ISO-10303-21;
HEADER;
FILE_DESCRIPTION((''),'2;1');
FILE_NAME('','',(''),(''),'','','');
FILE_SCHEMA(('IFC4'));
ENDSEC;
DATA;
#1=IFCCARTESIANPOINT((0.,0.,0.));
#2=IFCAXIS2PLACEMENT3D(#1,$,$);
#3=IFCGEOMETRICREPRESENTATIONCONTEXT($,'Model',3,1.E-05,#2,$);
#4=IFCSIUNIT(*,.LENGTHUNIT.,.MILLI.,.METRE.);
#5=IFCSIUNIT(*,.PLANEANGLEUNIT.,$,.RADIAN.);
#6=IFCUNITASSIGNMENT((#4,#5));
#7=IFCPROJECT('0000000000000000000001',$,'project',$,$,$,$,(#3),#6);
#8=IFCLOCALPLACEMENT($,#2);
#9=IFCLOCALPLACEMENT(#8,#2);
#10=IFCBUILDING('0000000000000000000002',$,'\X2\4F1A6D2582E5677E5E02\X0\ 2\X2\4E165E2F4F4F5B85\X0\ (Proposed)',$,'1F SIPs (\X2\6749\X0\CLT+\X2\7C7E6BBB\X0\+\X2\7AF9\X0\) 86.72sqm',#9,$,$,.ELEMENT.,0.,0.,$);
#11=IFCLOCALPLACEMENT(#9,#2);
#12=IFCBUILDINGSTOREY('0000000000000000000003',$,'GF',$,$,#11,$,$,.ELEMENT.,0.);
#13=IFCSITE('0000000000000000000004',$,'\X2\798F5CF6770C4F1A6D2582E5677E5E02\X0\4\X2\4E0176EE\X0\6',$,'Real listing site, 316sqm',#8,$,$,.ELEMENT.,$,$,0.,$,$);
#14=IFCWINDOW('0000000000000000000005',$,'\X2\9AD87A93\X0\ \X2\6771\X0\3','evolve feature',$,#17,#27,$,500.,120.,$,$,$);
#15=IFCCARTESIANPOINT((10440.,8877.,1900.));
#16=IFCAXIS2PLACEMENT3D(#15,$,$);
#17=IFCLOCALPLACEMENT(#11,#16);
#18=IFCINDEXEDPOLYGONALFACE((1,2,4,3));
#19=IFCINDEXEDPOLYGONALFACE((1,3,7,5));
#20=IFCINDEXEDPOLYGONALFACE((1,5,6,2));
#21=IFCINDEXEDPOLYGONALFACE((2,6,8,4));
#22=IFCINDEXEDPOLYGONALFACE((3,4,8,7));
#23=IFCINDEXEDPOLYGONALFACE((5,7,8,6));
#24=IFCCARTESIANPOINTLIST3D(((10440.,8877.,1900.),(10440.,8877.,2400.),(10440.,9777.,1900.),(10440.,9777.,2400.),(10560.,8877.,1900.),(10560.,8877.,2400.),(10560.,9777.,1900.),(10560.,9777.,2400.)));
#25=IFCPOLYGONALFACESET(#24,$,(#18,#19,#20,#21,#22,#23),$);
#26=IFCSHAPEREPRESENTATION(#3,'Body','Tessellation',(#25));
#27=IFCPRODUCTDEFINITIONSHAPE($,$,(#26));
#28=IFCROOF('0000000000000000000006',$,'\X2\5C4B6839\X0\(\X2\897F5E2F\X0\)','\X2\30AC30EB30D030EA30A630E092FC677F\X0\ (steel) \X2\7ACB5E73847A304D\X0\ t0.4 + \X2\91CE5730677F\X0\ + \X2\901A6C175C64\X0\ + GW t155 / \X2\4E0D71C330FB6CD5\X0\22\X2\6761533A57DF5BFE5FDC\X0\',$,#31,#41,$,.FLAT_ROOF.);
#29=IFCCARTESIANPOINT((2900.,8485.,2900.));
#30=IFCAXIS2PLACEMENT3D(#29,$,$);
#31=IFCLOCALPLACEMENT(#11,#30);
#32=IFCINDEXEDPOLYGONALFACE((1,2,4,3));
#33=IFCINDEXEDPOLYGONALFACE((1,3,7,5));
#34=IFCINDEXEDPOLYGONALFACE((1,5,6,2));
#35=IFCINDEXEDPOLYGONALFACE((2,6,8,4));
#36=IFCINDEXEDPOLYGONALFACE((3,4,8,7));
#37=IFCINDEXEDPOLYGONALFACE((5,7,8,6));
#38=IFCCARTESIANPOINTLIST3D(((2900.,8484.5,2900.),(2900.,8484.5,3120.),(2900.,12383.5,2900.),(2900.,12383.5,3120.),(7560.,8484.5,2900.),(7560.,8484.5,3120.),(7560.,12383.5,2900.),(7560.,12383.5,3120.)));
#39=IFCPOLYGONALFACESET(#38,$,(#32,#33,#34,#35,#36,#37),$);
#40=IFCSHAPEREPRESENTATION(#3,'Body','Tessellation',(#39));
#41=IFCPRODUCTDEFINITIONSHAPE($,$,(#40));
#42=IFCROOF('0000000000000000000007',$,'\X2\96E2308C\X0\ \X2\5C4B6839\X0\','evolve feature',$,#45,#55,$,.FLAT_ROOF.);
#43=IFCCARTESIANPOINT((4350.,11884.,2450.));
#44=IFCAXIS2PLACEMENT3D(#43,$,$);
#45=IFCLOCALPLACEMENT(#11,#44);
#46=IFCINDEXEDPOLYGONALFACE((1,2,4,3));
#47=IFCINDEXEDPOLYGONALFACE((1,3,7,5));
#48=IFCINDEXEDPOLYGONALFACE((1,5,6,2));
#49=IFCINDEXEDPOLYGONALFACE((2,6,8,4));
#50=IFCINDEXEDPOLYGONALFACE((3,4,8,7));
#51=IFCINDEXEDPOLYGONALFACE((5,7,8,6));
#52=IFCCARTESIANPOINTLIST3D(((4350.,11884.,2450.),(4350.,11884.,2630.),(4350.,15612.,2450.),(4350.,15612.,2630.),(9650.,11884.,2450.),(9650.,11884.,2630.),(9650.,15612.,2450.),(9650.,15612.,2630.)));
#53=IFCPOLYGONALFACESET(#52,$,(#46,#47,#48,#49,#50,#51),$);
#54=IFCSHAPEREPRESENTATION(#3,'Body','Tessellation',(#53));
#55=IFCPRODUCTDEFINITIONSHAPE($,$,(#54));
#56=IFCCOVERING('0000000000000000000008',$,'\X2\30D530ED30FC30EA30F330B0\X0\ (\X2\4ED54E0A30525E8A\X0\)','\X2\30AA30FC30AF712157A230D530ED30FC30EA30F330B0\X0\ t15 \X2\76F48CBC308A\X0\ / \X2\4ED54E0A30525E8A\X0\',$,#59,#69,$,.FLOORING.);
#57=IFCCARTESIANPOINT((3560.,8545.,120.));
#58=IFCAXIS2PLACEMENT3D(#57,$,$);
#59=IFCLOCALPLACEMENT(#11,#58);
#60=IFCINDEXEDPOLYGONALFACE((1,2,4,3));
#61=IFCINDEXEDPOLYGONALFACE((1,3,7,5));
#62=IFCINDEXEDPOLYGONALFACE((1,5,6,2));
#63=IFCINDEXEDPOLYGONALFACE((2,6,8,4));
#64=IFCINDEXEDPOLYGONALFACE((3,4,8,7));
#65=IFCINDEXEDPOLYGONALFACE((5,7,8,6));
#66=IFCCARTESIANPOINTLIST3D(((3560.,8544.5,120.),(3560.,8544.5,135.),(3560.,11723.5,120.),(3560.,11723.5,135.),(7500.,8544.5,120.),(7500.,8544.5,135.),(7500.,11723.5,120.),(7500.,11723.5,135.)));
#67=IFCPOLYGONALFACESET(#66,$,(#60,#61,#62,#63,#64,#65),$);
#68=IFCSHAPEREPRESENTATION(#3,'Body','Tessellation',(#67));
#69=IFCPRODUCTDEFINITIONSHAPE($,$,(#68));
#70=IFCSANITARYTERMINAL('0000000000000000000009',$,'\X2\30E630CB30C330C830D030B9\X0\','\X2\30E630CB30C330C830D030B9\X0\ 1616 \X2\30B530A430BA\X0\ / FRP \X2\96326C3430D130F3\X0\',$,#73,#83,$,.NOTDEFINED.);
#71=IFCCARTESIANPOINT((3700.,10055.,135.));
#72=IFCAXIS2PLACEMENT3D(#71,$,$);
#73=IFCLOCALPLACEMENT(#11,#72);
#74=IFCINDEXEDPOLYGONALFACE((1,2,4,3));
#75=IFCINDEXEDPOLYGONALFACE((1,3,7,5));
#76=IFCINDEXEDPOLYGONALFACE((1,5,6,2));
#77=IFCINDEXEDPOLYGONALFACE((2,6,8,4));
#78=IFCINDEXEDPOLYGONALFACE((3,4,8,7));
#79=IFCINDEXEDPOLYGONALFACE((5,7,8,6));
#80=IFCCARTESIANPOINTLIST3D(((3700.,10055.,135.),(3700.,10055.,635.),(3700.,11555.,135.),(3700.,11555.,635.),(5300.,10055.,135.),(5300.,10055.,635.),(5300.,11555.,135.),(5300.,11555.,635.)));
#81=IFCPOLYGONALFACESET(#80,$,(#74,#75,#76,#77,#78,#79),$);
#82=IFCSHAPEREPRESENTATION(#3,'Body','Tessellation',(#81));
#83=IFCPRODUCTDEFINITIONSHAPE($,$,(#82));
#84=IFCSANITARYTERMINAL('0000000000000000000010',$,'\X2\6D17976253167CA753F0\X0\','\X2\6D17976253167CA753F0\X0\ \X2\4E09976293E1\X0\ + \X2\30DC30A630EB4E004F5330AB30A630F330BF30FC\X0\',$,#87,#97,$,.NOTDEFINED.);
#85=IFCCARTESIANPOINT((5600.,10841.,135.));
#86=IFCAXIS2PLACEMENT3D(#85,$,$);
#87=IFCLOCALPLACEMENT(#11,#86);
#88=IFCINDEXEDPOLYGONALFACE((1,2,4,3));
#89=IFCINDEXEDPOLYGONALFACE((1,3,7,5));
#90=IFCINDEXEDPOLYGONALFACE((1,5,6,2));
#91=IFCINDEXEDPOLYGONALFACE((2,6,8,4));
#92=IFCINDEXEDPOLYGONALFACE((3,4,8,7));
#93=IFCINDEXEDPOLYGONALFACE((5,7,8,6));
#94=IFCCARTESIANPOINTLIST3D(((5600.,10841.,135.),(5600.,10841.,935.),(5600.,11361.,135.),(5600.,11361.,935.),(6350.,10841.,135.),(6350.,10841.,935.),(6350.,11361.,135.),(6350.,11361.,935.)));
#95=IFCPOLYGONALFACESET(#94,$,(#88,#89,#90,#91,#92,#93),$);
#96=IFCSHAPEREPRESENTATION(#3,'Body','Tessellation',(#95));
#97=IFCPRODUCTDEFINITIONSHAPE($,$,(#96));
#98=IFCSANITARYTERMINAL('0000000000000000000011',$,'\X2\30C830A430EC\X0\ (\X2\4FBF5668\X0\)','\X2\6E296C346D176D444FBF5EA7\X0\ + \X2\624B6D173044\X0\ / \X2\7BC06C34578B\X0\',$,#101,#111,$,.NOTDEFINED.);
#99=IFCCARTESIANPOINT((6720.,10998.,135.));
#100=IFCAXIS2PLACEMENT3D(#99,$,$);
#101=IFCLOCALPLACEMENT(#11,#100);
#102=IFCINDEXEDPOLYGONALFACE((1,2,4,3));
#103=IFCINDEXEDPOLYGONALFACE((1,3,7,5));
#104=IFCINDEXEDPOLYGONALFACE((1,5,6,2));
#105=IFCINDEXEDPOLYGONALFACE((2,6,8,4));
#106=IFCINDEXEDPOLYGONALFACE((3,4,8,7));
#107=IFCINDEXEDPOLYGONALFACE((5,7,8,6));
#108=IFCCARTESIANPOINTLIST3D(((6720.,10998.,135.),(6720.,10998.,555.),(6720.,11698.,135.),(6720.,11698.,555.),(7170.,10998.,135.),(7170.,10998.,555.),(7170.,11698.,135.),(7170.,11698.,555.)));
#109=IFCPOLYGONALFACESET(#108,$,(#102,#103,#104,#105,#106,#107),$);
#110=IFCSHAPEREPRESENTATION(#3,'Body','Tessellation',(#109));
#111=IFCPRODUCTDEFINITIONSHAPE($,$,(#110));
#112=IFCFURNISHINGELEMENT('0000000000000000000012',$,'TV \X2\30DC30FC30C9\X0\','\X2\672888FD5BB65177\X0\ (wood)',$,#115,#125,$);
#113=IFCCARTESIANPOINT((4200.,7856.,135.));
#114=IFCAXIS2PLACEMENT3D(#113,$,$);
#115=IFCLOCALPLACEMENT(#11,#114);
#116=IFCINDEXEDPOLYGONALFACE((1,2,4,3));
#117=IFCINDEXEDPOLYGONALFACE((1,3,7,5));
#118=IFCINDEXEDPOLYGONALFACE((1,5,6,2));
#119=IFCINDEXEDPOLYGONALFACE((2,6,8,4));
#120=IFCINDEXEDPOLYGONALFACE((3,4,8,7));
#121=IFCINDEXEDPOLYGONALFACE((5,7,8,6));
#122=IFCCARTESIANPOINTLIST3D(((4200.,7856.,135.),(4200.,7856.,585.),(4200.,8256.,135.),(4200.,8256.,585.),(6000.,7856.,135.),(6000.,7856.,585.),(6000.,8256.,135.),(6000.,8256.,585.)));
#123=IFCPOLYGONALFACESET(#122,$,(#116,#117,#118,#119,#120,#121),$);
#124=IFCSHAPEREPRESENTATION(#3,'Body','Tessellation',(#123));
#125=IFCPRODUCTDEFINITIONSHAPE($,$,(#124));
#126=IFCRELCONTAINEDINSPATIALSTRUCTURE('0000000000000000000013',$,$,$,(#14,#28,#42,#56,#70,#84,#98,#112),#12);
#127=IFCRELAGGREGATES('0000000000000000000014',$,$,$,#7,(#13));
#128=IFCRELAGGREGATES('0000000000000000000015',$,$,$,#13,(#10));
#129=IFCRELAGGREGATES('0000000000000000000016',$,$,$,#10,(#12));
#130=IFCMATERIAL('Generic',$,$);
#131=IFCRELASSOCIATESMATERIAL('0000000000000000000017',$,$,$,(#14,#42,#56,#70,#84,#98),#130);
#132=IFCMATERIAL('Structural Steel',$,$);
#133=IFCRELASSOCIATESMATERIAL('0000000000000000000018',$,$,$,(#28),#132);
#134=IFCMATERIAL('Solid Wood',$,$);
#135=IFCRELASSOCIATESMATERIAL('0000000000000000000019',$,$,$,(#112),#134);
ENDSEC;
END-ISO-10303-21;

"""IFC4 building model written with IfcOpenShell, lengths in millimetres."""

from ifc_helpers import new_model, si_unit, frame, frame_2d, origin, place, context, project, spatial, rectangle, extrude, material, element, save


model = new_model("IFC4")

# Units and contexts
model_context = context("Model", 3, precision=1e-05, world=origin())
ifc_project = project(units=[si_unit("LENGTHUNIT", "METRE", prefix="MILLI"), si_unit("PLANEANGLEUNIT", "RADIAN")], contexts=[model_context])

# Site, building, storey
site_placement = place(None, origin())
site = spatial("IfcSite", under=ifc_project, at=site_placement, Name="福島県会津若松市4丁目6", ObjectType="Real listing site, 316sqm", CompositionType="ELEMENT", RefElevation=0.0)
building_placement = place(site_placement, origin())
building = spatial("IfcBuilding", under=site, at=building_placement, Name="会津若松市 2世帯住宅 (Proposed)", ObjectType="1F SIPs (杉CLT+籾殻+竹) 86.72sqm", CompositionType="ELEMENT", ElevationOfRefHeight=0.0, ElevationOfTerrain=0.0)
storey_placement = place(building_placement, origin())
storey = spatial("IfcBuildingStorey", under=building, at=storey_placement, Name="GF", CompositionType="ELEMENT", Elevation=0.0)

# Shared definitions
ifc_material_1 = material(Name="Solid Wood")
ifc_material_2 = material(Name="Generic")

# Window
window_1_placement = place(storey_placement, frame((10440.0, 8877.0, 1900.0)))
element("IfcWindow", 1, at=window_1_placement, inside=storey, material=ifc_material_2, Name="高窓 東3", Description="evolve feature", OverallHeight=500.0, OverallWidth=120.0, context=model_context, shape_type="SweptSolid", body=[
    extrude(rectangle(XDim=120.0, YDim=900.0, at=frame_2d((60.0, 450.0))), frame((10440.0, 8877.0, 1900.0)), (0.0, 0.0, 1.0), 500.0),
])

# Roofs
ifc_material_3 = material(Name="Structural Steel")
roof_1_placement = place(storey_placement, frame((2900.0, 8485.0, 2900.0)))
element("IfcRoof", 2, at=roof_1_placement, inside=storey, material=ifc_material_3, Name="屋根(西帯)", Description="ガルバリウム鋼板 (steel) 立平葺き t0.4 + 野地板 + 通気層 + GW t155 / 不燃・法22条区域対応", PredefinedType="FLAT_ROOF", context=model_context, shape_type="SweptSolid", body=[
    extrude(rectangle(XDim=4660.0, YDim=3899.0, at=frame_2d((2330.0, 1949.0))), frame((2900.0, 8485.0, 2900.0)), (0.0, 0.0, 1.0), 220.0),
])
roof_2_placement = place(storey_placement, frame((4350.0, 11884.0, 2450.0)))
element("IfcRoof", 3, at=roof_2_placement, inside=storey, material=ifc_material_2, Name="離れ 屋根", Description="evolve feature", PredefinedType="FLAT_ROOF", context=model_context, shape_type="SweptSolid", body=[
    extrude(rectangle(XDim=5300.0, YDim=3728.0, at=frame_2d((2650.0, 1864.0))), frame((4350.0, 11884.0, 2450.0)), (0.0, 0.0, 1.0), 180.0),
])

# Covering
covering_placement = place(storey_placement, frame((3560.0, 8545.0, 120.0)))
element("IfcCovering", 4, at=covering_placement, inside=storey, material=ifc_material_2, Name="フローリング (仕上げ床)", Description="オーク無垢フローリング t15 直貼り / 仕上げ床", PredefinedType="FLOORING", context=model_context, shape_type="SweptSolid", body=[
    extrude(rectangle(XDim=3940.0, YDim=3179.0, at=frame_2d((1970.0, 1589.0))), frame((3560.0, 8545.0, 120.0)), (0.0, 0.0, 1.0), 15.0),
])

# Sanitary terminals
sanitary_terminal_1_placement = place(storey_placement, frame((3700.0, 10055.0, 135.0)))
element("IfcSanitaryTerminal", 5, at=sanitary_terminal_1_placement, inside=storey, material=ifc_material_2, Name="ユニットバス", Description="ユニットバス 1616 サイズ / FRP 防水パン", PredefinedType="NOTDEFINED", context=model_context, shape_type="SweptSolid", body=[
    extrude(rectangle(XDim=1600.0, YDim=1500.0, at=frame_2d((800.0, 750.0))), frame((3700.0, 10055.0, 135.0)), (0.0, 0.0, 1.0), 500.0),
])
sanitary_terminal_2_placement = place(storey_placement, frame((5600.0, 10841.0, 135.0)))
element("IfcSanitaryTerminal", 6, at=sanitary_terminal_2_placement, inside=storey, material=ifc_material_2, Name="洗面化粧台", Description="洗面化粧台 三面鏡 + ボウル一体カウンター", PredefinedType="NOTDEFINED", context=model_context, shape_type="SweptSolid", body=[
    extrude(rectangle(XDim=750.0, YDim=520.0, at=frame_2d((375.0, 260.0))), frame((5600.0, 10841.0, 135.0)), (0.0, 0.0, 1.0), 800.0),
])
sanitary_terminal_3_placement = place(storey_placement, frame((6720.0, 10998.0, 135.0)))
element("IfcSanitaryTerminal", 7, at=sanitary_terminal_3_placement, inside=storey, material=ifc_material_2, Name="トイレ (便器)", Description="温水洗浄便座 + 手洗い / 節水型", PredefinedType="NOTDEFINED", context=model_context, shape_type="SweptSolid", body=[
    extrude(rectangle(XDim=450.0, YDim=700.0, at=frame_2d((225.0, 350.0))), frame((6720.0, 10998.0, 135.0)), (0.0, 0.0, 1.0), 420.0),
])

# Furnishing element
furnishing_placement = place(storey_placement, frame((4200.0, 7856.0, 135.0)))
element("IfcFurnishingElement", 8, at=furnishing_placement, inside=storey, material=ifc_material_1, Name="TV ボード", Description="木製家具 (wood)", context=model_context, shape_type="SweptSolid", body=[
    extrude(rectangle(XDim=1800.0, YDim=400.0, at=frame_2d((900.0, 200.0))), frame((4200.0, 7856.0, 135.0)), (0.0, 0.0, 1.0), 450.0),
])

save(model, "model.ifc")
